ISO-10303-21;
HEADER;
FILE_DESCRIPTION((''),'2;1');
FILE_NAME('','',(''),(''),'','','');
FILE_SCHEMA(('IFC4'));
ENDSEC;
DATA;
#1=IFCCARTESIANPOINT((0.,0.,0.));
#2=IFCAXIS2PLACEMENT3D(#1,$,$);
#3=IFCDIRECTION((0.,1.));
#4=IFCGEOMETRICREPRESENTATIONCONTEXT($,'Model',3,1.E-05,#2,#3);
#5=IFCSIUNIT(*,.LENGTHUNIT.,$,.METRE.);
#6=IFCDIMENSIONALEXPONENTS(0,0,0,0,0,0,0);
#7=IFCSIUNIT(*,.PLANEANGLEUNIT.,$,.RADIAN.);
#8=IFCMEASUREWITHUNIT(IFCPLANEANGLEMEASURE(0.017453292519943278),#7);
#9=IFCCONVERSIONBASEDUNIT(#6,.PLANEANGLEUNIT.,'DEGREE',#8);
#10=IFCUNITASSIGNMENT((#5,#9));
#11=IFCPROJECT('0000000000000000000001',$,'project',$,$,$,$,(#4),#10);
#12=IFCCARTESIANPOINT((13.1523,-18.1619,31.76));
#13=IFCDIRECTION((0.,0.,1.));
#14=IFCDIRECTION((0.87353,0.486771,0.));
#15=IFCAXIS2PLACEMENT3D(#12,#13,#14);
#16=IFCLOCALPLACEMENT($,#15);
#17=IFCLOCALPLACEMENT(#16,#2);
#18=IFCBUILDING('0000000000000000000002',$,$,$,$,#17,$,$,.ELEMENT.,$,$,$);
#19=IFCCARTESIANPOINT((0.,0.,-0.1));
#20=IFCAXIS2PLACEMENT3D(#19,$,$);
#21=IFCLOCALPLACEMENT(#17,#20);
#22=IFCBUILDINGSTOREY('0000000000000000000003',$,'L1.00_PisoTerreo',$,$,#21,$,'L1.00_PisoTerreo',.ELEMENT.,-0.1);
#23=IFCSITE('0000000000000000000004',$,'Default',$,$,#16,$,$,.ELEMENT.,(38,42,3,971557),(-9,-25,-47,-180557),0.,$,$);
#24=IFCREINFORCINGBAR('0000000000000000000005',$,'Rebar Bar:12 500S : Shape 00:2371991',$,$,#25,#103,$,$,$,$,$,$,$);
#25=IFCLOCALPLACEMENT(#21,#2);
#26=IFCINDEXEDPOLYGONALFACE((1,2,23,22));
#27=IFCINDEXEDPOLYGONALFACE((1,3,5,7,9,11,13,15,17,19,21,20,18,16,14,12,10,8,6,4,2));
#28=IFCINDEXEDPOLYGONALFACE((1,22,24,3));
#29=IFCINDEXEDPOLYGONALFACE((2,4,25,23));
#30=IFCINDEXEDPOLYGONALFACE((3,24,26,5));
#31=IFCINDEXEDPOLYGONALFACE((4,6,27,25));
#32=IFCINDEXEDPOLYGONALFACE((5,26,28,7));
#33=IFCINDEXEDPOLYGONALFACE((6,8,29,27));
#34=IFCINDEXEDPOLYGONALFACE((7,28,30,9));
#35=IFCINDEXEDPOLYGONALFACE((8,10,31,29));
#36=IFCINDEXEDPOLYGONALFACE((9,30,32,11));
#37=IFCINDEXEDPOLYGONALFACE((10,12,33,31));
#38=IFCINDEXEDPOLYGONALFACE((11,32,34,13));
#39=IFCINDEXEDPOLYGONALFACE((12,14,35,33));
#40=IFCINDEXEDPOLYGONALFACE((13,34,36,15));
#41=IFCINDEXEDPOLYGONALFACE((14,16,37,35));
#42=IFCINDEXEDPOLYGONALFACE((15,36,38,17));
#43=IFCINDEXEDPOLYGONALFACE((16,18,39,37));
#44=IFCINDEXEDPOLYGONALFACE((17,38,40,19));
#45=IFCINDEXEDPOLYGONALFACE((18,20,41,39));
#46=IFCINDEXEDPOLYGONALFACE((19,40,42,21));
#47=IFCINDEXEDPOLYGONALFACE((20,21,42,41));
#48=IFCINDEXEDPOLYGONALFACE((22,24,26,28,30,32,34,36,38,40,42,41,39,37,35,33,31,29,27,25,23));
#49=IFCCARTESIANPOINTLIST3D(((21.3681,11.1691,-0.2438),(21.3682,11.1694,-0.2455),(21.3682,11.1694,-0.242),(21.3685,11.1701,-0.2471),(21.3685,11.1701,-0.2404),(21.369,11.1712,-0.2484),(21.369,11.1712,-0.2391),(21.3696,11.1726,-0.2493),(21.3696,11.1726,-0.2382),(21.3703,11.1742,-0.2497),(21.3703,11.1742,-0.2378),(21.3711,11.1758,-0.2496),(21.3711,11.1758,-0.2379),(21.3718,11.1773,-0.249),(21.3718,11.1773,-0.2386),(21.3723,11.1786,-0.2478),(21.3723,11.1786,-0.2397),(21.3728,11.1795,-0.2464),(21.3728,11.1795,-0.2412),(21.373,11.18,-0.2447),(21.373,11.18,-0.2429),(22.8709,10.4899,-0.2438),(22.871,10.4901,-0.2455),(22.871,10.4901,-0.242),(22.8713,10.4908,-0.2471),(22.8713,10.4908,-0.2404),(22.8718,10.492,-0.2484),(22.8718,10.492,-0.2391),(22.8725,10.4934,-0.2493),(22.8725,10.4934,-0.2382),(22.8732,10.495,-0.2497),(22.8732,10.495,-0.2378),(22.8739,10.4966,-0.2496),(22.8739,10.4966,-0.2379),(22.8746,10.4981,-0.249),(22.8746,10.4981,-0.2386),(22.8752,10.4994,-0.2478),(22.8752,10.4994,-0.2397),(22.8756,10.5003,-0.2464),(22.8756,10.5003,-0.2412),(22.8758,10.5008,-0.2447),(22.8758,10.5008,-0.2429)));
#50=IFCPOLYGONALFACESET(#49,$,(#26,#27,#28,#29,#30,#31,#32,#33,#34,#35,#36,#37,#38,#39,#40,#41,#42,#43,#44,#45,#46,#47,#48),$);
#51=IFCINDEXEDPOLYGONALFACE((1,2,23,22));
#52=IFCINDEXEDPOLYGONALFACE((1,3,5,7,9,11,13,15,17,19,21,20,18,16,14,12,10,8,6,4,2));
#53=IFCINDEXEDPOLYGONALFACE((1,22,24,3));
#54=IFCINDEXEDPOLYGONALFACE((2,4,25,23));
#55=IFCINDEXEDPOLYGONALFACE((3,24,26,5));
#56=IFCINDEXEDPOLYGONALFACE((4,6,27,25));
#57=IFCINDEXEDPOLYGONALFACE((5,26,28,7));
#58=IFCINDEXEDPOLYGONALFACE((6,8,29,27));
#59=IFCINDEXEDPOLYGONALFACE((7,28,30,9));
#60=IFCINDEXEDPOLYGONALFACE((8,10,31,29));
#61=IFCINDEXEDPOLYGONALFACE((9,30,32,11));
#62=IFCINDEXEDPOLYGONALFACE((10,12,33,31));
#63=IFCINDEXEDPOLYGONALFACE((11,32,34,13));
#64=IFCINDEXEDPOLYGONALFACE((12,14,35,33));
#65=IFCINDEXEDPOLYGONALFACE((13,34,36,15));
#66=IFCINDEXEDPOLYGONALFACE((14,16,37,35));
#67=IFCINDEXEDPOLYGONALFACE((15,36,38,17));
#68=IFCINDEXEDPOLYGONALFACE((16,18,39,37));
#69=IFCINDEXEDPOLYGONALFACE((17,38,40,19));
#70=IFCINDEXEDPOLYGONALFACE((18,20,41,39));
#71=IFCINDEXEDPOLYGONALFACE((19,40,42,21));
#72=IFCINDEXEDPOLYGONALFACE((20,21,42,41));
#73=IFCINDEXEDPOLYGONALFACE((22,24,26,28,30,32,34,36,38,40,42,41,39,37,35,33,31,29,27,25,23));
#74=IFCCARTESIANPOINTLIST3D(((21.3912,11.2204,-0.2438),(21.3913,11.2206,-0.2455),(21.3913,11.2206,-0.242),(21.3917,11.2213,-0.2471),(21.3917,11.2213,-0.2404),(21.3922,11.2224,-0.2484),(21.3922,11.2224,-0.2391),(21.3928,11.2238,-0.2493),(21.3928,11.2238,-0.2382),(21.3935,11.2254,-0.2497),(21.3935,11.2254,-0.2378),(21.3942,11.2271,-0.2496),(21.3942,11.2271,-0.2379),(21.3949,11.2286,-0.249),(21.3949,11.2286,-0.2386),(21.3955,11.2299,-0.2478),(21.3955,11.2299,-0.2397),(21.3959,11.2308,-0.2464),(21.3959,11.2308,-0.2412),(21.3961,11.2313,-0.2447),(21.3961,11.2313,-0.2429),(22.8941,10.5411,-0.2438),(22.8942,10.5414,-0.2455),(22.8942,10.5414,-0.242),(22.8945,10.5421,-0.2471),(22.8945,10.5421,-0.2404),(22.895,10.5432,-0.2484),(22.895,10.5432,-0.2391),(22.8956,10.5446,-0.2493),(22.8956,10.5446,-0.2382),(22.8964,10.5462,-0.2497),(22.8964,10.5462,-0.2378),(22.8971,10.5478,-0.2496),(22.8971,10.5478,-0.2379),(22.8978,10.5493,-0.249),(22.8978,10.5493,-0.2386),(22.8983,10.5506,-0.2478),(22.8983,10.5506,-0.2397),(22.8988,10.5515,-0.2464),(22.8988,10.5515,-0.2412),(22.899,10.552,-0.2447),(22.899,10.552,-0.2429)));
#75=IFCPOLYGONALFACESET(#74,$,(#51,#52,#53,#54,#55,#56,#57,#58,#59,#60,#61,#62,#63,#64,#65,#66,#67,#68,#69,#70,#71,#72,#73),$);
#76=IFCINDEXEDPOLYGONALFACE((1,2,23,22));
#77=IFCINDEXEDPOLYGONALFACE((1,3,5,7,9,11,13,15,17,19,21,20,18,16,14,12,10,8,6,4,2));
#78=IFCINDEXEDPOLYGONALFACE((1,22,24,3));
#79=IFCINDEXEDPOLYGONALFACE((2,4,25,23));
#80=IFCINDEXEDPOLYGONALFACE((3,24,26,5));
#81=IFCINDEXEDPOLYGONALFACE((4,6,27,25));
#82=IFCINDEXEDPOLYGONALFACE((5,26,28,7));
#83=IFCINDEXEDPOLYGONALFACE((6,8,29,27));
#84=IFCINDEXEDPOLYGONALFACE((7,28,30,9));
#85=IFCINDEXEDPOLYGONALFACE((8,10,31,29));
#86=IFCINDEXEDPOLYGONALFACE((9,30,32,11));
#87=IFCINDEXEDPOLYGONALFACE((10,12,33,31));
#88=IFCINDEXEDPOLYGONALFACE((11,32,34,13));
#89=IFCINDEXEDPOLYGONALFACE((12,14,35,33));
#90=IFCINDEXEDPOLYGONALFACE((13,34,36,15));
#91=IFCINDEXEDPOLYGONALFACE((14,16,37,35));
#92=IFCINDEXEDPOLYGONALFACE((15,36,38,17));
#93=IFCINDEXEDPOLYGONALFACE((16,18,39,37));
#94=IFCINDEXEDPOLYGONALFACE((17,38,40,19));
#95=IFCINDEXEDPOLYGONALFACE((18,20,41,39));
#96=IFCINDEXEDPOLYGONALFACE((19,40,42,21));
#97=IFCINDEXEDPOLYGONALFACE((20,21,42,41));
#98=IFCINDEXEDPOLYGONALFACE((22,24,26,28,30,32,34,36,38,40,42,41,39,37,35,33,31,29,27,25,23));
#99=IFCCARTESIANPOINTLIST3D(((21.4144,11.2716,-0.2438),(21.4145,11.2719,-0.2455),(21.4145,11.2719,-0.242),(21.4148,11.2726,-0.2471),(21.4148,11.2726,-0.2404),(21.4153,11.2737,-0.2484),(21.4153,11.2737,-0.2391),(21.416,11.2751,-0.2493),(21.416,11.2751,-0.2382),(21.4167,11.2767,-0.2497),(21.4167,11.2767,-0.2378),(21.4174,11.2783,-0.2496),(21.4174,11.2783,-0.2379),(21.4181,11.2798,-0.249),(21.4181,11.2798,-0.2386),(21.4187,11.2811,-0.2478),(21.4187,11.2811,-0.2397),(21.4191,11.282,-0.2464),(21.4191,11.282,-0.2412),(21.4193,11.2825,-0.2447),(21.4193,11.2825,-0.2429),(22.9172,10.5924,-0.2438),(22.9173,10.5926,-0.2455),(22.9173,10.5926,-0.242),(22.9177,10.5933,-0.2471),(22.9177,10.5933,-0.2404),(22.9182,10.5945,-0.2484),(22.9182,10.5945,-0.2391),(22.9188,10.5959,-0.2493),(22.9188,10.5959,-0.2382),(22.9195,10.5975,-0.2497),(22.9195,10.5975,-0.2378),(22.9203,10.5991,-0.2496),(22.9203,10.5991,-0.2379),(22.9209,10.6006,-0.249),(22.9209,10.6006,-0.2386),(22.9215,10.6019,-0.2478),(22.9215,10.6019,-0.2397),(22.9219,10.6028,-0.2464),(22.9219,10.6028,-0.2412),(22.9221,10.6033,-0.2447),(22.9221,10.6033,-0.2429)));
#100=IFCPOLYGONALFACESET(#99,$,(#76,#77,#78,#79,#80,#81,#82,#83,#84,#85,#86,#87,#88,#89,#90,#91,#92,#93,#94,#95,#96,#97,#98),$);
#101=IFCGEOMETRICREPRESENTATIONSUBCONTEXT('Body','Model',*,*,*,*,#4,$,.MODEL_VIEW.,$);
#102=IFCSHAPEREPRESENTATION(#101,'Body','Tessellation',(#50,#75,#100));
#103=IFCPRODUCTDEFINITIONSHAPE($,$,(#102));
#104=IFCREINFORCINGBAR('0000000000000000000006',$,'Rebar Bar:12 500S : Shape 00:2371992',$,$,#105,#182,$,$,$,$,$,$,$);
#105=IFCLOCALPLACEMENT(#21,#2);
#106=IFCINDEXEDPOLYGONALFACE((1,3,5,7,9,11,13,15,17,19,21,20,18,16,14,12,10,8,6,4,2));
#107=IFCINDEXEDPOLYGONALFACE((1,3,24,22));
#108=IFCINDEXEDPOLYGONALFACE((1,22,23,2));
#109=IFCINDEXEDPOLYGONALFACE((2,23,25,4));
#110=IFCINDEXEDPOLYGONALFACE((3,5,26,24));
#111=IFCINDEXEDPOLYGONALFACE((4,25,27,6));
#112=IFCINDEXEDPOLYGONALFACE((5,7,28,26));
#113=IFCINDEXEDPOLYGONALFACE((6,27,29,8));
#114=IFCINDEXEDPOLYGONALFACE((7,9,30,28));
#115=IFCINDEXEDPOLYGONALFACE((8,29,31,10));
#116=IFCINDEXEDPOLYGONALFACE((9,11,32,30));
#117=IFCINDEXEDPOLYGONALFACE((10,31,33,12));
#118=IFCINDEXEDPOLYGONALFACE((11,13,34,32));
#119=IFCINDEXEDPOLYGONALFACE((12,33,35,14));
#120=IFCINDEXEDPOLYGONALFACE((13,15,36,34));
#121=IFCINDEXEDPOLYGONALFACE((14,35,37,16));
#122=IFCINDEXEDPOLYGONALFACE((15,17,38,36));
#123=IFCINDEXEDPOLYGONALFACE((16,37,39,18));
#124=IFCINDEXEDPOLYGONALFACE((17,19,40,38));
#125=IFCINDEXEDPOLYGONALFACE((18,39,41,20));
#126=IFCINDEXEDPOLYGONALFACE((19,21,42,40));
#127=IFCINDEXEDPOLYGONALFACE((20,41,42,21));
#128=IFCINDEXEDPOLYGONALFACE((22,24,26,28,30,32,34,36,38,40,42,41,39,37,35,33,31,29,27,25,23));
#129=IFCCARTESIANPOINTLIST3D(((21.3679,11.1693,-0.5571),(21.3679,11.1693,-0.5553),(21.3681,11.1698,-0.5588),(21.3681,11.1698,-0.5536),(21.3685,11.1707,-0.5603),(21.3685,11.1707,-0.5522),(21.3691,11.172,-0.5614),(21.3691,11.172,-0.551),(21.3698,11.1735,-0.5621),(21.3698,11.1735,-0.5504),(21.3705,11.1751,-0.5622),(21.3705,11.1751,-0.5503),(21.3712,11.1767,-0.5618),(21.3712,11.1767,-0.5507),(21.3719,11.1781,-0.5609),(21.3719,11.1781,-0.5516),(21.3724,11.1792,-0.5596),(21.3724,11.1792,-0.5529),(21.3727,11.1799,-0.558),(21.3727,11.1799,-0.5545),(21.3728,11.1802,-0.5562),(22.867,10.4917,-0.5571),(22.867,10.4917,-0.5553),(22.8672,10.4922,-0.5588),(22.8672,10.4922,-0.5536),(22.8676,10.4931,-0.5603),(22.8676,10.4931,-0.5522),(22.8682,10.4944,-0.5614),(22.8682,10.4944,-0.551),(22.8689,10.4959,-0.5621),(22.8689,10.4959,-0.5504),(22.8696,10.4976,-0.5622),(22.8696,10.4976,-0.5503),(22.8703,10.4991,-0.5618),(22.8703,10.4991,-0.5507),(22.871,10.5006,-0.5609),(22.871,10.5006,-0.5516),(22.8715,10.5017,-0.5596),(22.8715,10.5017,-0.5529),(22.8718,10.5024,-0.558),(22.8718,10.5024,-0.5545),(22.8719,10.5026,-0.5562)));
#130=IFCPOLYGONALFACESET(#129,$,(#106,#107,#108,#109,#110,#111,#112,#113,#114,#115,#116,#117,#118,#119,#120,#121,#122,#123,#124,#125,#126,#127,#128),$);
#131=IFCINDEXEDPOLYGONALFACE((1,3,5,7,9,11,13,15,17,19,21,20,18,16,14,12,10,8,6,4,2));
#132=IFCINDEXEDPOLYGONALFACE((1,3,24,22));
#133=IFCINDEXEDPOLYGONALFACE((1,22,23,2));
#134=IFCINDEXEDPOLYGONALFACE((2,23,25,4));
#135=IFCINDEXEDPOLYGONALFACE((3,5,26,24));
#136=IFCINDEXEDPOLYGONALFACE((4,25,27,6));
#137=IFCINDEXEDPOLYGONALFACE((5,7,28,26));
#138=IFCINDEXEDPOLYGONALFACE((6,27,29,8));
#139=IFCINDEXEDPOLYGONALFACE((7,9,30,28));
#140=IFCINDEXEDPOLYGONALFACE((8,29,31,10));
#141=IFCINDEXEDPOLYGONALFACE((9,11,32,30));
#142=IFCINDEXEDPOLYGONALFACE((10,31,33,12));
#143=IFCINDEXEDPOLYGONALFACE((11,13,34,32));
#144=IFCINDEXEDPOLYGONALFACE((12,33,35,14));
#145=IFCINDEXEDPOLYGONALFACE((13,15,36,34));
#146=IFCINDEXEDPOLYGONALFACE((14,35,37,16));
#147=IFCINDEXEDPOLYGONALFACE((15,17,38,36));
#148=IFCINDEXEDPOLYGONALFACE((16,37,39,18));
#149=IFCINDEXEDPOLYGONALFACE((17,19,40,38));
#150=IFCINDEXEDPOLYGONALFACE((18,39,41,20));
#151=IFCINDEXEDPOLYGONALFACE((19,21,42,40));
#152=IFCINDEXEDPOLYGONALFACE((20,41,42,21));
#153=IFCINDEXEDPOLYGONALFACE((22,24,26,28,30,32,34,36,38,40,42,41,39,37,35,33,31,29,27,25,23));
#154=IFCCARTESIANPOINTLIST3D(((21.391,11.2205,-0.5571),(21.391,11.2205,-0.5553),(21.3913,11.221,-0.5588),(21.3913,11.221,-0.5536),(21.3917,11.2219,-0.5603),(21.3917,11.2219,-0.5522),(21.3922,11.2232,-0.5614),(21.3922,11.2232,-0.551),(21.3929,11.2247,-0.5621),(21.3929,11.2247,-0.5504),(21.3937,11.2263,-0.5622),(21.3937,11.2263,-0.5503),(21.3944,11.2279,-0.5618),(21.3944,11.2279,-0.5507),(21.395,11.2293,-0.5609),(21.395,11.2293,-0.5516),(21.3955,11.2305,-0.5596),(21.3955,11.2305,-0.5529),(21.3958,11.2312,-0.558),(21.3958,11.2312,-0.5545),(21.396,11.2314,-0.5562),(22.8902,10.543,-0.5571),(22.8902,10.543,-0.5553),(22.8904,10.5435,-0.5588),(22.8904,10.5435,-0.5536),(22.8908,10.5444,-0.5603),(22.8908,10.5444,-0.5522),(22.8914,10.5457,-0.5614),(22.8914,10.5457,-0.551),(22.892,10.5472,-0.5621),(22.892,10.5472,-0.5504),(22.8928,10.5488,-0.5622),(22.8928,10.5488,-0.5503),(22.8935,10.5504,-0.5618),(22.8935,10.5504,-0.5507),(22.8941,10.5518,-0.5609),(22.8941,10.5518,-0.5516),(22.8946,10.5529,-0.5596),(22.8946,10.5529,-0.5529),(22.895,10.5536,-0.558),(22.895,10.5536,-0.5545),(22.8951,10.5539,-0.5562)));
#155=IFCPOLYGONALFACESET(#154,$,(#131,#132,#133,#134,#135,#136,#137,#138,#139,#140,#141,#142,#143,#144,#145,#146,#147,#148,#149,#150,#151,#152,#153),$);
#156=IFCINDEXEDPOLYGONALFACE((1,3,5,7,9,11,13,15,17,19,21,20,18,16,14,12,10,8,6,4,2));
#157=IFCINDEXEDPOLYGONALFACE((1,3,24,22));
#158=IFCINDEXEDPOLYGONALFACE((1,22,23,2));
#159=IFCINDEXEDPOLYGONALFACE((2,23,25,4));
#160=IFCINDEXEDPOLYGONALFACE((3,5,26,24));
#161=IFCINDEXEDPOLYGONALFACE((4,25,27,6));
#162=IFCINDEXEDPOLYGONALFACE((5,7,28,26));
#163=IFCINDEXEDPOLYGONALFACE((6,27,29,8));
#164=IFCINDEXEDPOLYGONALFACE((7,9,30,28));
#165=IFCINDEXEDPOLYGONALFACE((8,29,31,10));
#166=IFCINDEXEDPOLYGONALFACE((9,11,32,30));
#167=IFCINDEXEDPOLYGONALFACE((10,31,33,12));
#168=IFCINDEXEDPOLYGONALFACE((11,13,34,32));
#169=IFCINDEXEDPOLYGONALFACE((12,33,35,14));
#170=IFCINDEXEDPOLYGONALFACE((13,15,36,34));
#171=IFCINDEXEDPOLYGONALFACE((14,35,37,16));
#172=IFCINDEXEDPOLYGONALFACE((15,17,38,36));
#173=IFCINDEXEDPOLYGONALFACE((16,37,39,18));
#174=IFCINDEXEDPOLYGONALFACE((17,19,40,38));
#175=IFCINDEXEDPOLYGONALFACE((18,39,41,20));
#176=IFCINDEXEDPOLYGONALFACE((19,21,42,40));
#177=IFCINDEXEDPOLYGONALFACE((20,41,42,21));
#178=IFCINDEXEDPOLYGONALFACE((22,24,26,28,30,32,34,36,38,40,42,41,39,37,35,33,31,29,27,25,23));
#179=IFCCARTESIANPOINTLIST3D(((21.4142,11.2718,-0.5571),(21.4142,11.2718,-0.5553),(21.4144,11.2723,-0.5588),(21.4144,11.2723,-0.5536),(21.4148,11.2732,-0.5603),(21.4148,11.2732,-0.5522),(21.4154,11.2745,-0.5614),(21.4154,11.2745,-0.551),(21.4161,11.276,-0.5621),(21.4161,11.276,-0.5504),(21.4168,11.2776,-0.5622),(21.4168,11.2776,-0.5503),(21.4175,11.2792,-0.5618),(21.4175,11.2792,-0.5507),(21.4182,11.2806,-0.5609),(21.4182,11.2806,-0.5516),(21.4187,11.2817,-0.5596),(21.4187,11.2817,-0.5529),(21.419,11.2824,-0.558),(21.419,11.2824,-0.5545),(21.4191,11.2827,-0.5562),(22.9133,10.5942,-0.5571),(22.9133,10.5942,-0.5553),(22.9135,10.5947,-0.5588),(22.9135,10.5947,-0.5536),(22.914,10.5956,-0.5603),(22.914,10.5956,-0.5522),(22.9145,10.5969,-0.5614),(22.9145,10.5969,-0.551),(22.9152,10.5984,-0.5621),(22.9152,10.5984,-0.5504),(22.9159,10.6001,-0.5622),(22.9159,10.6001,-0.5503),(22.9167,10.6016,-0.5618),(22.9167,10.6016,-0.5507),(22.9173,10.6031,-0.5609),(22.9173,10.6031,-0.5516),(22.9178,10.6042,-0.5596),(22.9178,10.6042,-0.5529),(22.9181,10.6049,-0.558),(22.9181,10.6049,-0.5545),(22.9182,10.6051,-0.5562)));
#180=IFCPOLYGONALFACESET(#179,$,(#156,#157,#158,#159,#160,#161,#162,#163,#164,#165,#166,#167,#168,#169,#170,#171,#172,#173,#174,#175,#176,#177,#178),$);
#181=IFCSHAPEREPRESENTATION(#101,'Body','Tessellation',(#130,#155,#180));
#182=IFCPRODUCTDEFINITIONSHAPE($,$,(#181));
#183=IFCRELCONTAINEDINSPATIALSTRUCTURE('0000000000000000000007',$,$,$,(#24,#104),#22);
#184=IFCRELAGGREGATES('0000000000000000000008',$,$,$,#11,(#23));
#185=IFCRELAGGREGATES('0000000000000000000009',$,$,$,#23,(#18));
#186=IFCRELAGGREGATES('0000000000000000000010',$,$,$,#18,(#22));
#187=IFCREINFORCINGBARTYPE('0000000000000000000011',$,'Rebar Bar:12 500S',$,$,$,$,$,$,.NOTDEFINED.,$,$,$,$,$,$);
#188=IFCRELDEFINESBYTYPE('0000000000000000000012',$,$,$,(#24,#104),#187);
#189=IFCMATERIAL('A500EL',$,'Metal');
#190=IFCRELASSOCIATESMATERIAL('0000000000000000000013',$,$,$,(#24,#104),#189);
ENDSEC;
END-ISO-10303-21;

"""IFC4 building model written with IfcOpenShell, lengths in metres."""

from ifc_helpers import new_model, entity, si_unit, converted_unit, direction, frame, origin, place, context, subcontext, project, spatial, material, type_object, element, save


model = new_model("IFC4")

# Units and contexts
model_context = context("Model", 3, precision=1e-05, world=origin(), true_north=direction((0.0, 1.0)))
body_context = subcontext(model_context, "Body", "Model", "MODEL_VIEW")
ifc_project = project(units=[si_unit("LENGTHUNIT", "METRE"), converted_unit("PLANEANGLEUNIT", "DEGREE", entity("IfcPlaneAngleMeasure", 0.017453292519943278), si_unit("PLANEANGLEUNIT", "RADIAN"), dimensions=[0, 0, 0, 0, 0, 0, 0])], contexts=[model_context])

# Site, building, storey
site_placement = place(None, frame((13.1523, -18.1619, 31.76), z_axis=(0.0, 0.0, 1.0), x_axis=(0.87353, 0.486771, 0.0)))
site = spatial("IfcSite", under=ifc_project, at=site_placement, Name="Default", CompositionType="ELEMENT", RefLatitude=(38, 42, 3, 971557), RefLongitude=(-9, -25, -47, -180557), RefElevation=0.0)
building_placement = place(site_placement, origin())
building = spatial("IfcBuilding", under=site, at=building_placement, CompositionType="ELEMENT")
storey_placement = place(building_placement, frame((0.0, 0.0, -0.1)))
storey = spatial("IfcBuildingStorey", under=building, at=storey_placement, Name="L1.00_PisoTerreo", LongName="L1.00_PisoTerreo", CompositionType="ELEMENT", Elevation=-0.1)

# Reinforcing bars
ifc_material = material(Name="A500EL", Category="Metal")
reinforcing_bar_type_1 = type_object("IfcReinforcingBarType", Name="Rebar Bar:12 500S", PredefinedType="NOTDEFINED")
reinforcing_bar_1_placement = place(storey_placement, origin())
element("IfcReinforcingBar", 1, at=reinforcing_bar_1_placement, inside=storey, type_object=reinforcing_bar_type_1, material=ifc_material, Name="Rebar Bar:12 500S : Shape 00:2371991", context=body_context, shape_type="AdvancedSweptSolid", body=[
    entity("IfcSweptDiskSolid", entity("IfcIndexedPolyCurve", entity("IfcCartesianPointList3D", [[22.8734, 10.4954, -0.2438], [21.3705, 11.1746, -0.2438]]), None, False), 0.006, None, 0.0, 1.0),
    entity("IfcSweptDiskSolid", entity("IfcIndexedPolyCurve", entity("IfcCartesianPointList3D", [[22.8965, 10.5466, -0.2438], [21.3937, 11.2258, -0.2438]]), None, False), 0.006, None, 0.0, 1.0),
    entity("IfcSweptDiskSolid", entity("IfcIndexedPolyCurve", entity("IfcCartesianPointList3D", [[22.9197, 10.5979, -0.2438], [21.4169, 11.2771, -0.2438]]), None, False), 0.006, None, 0.0, 1.0),
])
reinforcing_bar_2_placement = place(storey_placement, origin())
element("IfcReinforcingBar", 2, at=reinforcing_bar_2_placement, inside=storey, type_object=reinforcing_bar_type_1, material=ifc_material, Name="Rebar Bar:12 500S : Shape 00:2371992", context=body_context, shape_type="AdvancedSweptSolid", body=[
    entity("IfcSweptDiskSolid", entity("IfcIndexedPolyCurve", entity("IfcCartesianPointList3D", [[21.3703, 11.1747, -0.5562], [22.8694, 10.4971, -0.5562]]), None, False), 0.006, None, 0.0, 1.0),
    entity("IfcSweptDiskSolid", entity("IfcIndexedPolyCurve", entity("IfcCartesianPointList3D", [[21.3935, 11.2259, -0.5562], [22.8926, 10.5484, -0.5562]]), None, False), 0.006, None, 0.0, 1.0),
    entity("IfcSweptDiskSolid", entity("IfcIndexedPolyCurve", entity("IfcCartesianPointList3D", [[21.4166, 11.2772, -0.5562], [22.9158, 10.5996, -0.5562]]), None, False), 0.006, None, 0.0, 1.0),
])

save(model, "model.ifc")
